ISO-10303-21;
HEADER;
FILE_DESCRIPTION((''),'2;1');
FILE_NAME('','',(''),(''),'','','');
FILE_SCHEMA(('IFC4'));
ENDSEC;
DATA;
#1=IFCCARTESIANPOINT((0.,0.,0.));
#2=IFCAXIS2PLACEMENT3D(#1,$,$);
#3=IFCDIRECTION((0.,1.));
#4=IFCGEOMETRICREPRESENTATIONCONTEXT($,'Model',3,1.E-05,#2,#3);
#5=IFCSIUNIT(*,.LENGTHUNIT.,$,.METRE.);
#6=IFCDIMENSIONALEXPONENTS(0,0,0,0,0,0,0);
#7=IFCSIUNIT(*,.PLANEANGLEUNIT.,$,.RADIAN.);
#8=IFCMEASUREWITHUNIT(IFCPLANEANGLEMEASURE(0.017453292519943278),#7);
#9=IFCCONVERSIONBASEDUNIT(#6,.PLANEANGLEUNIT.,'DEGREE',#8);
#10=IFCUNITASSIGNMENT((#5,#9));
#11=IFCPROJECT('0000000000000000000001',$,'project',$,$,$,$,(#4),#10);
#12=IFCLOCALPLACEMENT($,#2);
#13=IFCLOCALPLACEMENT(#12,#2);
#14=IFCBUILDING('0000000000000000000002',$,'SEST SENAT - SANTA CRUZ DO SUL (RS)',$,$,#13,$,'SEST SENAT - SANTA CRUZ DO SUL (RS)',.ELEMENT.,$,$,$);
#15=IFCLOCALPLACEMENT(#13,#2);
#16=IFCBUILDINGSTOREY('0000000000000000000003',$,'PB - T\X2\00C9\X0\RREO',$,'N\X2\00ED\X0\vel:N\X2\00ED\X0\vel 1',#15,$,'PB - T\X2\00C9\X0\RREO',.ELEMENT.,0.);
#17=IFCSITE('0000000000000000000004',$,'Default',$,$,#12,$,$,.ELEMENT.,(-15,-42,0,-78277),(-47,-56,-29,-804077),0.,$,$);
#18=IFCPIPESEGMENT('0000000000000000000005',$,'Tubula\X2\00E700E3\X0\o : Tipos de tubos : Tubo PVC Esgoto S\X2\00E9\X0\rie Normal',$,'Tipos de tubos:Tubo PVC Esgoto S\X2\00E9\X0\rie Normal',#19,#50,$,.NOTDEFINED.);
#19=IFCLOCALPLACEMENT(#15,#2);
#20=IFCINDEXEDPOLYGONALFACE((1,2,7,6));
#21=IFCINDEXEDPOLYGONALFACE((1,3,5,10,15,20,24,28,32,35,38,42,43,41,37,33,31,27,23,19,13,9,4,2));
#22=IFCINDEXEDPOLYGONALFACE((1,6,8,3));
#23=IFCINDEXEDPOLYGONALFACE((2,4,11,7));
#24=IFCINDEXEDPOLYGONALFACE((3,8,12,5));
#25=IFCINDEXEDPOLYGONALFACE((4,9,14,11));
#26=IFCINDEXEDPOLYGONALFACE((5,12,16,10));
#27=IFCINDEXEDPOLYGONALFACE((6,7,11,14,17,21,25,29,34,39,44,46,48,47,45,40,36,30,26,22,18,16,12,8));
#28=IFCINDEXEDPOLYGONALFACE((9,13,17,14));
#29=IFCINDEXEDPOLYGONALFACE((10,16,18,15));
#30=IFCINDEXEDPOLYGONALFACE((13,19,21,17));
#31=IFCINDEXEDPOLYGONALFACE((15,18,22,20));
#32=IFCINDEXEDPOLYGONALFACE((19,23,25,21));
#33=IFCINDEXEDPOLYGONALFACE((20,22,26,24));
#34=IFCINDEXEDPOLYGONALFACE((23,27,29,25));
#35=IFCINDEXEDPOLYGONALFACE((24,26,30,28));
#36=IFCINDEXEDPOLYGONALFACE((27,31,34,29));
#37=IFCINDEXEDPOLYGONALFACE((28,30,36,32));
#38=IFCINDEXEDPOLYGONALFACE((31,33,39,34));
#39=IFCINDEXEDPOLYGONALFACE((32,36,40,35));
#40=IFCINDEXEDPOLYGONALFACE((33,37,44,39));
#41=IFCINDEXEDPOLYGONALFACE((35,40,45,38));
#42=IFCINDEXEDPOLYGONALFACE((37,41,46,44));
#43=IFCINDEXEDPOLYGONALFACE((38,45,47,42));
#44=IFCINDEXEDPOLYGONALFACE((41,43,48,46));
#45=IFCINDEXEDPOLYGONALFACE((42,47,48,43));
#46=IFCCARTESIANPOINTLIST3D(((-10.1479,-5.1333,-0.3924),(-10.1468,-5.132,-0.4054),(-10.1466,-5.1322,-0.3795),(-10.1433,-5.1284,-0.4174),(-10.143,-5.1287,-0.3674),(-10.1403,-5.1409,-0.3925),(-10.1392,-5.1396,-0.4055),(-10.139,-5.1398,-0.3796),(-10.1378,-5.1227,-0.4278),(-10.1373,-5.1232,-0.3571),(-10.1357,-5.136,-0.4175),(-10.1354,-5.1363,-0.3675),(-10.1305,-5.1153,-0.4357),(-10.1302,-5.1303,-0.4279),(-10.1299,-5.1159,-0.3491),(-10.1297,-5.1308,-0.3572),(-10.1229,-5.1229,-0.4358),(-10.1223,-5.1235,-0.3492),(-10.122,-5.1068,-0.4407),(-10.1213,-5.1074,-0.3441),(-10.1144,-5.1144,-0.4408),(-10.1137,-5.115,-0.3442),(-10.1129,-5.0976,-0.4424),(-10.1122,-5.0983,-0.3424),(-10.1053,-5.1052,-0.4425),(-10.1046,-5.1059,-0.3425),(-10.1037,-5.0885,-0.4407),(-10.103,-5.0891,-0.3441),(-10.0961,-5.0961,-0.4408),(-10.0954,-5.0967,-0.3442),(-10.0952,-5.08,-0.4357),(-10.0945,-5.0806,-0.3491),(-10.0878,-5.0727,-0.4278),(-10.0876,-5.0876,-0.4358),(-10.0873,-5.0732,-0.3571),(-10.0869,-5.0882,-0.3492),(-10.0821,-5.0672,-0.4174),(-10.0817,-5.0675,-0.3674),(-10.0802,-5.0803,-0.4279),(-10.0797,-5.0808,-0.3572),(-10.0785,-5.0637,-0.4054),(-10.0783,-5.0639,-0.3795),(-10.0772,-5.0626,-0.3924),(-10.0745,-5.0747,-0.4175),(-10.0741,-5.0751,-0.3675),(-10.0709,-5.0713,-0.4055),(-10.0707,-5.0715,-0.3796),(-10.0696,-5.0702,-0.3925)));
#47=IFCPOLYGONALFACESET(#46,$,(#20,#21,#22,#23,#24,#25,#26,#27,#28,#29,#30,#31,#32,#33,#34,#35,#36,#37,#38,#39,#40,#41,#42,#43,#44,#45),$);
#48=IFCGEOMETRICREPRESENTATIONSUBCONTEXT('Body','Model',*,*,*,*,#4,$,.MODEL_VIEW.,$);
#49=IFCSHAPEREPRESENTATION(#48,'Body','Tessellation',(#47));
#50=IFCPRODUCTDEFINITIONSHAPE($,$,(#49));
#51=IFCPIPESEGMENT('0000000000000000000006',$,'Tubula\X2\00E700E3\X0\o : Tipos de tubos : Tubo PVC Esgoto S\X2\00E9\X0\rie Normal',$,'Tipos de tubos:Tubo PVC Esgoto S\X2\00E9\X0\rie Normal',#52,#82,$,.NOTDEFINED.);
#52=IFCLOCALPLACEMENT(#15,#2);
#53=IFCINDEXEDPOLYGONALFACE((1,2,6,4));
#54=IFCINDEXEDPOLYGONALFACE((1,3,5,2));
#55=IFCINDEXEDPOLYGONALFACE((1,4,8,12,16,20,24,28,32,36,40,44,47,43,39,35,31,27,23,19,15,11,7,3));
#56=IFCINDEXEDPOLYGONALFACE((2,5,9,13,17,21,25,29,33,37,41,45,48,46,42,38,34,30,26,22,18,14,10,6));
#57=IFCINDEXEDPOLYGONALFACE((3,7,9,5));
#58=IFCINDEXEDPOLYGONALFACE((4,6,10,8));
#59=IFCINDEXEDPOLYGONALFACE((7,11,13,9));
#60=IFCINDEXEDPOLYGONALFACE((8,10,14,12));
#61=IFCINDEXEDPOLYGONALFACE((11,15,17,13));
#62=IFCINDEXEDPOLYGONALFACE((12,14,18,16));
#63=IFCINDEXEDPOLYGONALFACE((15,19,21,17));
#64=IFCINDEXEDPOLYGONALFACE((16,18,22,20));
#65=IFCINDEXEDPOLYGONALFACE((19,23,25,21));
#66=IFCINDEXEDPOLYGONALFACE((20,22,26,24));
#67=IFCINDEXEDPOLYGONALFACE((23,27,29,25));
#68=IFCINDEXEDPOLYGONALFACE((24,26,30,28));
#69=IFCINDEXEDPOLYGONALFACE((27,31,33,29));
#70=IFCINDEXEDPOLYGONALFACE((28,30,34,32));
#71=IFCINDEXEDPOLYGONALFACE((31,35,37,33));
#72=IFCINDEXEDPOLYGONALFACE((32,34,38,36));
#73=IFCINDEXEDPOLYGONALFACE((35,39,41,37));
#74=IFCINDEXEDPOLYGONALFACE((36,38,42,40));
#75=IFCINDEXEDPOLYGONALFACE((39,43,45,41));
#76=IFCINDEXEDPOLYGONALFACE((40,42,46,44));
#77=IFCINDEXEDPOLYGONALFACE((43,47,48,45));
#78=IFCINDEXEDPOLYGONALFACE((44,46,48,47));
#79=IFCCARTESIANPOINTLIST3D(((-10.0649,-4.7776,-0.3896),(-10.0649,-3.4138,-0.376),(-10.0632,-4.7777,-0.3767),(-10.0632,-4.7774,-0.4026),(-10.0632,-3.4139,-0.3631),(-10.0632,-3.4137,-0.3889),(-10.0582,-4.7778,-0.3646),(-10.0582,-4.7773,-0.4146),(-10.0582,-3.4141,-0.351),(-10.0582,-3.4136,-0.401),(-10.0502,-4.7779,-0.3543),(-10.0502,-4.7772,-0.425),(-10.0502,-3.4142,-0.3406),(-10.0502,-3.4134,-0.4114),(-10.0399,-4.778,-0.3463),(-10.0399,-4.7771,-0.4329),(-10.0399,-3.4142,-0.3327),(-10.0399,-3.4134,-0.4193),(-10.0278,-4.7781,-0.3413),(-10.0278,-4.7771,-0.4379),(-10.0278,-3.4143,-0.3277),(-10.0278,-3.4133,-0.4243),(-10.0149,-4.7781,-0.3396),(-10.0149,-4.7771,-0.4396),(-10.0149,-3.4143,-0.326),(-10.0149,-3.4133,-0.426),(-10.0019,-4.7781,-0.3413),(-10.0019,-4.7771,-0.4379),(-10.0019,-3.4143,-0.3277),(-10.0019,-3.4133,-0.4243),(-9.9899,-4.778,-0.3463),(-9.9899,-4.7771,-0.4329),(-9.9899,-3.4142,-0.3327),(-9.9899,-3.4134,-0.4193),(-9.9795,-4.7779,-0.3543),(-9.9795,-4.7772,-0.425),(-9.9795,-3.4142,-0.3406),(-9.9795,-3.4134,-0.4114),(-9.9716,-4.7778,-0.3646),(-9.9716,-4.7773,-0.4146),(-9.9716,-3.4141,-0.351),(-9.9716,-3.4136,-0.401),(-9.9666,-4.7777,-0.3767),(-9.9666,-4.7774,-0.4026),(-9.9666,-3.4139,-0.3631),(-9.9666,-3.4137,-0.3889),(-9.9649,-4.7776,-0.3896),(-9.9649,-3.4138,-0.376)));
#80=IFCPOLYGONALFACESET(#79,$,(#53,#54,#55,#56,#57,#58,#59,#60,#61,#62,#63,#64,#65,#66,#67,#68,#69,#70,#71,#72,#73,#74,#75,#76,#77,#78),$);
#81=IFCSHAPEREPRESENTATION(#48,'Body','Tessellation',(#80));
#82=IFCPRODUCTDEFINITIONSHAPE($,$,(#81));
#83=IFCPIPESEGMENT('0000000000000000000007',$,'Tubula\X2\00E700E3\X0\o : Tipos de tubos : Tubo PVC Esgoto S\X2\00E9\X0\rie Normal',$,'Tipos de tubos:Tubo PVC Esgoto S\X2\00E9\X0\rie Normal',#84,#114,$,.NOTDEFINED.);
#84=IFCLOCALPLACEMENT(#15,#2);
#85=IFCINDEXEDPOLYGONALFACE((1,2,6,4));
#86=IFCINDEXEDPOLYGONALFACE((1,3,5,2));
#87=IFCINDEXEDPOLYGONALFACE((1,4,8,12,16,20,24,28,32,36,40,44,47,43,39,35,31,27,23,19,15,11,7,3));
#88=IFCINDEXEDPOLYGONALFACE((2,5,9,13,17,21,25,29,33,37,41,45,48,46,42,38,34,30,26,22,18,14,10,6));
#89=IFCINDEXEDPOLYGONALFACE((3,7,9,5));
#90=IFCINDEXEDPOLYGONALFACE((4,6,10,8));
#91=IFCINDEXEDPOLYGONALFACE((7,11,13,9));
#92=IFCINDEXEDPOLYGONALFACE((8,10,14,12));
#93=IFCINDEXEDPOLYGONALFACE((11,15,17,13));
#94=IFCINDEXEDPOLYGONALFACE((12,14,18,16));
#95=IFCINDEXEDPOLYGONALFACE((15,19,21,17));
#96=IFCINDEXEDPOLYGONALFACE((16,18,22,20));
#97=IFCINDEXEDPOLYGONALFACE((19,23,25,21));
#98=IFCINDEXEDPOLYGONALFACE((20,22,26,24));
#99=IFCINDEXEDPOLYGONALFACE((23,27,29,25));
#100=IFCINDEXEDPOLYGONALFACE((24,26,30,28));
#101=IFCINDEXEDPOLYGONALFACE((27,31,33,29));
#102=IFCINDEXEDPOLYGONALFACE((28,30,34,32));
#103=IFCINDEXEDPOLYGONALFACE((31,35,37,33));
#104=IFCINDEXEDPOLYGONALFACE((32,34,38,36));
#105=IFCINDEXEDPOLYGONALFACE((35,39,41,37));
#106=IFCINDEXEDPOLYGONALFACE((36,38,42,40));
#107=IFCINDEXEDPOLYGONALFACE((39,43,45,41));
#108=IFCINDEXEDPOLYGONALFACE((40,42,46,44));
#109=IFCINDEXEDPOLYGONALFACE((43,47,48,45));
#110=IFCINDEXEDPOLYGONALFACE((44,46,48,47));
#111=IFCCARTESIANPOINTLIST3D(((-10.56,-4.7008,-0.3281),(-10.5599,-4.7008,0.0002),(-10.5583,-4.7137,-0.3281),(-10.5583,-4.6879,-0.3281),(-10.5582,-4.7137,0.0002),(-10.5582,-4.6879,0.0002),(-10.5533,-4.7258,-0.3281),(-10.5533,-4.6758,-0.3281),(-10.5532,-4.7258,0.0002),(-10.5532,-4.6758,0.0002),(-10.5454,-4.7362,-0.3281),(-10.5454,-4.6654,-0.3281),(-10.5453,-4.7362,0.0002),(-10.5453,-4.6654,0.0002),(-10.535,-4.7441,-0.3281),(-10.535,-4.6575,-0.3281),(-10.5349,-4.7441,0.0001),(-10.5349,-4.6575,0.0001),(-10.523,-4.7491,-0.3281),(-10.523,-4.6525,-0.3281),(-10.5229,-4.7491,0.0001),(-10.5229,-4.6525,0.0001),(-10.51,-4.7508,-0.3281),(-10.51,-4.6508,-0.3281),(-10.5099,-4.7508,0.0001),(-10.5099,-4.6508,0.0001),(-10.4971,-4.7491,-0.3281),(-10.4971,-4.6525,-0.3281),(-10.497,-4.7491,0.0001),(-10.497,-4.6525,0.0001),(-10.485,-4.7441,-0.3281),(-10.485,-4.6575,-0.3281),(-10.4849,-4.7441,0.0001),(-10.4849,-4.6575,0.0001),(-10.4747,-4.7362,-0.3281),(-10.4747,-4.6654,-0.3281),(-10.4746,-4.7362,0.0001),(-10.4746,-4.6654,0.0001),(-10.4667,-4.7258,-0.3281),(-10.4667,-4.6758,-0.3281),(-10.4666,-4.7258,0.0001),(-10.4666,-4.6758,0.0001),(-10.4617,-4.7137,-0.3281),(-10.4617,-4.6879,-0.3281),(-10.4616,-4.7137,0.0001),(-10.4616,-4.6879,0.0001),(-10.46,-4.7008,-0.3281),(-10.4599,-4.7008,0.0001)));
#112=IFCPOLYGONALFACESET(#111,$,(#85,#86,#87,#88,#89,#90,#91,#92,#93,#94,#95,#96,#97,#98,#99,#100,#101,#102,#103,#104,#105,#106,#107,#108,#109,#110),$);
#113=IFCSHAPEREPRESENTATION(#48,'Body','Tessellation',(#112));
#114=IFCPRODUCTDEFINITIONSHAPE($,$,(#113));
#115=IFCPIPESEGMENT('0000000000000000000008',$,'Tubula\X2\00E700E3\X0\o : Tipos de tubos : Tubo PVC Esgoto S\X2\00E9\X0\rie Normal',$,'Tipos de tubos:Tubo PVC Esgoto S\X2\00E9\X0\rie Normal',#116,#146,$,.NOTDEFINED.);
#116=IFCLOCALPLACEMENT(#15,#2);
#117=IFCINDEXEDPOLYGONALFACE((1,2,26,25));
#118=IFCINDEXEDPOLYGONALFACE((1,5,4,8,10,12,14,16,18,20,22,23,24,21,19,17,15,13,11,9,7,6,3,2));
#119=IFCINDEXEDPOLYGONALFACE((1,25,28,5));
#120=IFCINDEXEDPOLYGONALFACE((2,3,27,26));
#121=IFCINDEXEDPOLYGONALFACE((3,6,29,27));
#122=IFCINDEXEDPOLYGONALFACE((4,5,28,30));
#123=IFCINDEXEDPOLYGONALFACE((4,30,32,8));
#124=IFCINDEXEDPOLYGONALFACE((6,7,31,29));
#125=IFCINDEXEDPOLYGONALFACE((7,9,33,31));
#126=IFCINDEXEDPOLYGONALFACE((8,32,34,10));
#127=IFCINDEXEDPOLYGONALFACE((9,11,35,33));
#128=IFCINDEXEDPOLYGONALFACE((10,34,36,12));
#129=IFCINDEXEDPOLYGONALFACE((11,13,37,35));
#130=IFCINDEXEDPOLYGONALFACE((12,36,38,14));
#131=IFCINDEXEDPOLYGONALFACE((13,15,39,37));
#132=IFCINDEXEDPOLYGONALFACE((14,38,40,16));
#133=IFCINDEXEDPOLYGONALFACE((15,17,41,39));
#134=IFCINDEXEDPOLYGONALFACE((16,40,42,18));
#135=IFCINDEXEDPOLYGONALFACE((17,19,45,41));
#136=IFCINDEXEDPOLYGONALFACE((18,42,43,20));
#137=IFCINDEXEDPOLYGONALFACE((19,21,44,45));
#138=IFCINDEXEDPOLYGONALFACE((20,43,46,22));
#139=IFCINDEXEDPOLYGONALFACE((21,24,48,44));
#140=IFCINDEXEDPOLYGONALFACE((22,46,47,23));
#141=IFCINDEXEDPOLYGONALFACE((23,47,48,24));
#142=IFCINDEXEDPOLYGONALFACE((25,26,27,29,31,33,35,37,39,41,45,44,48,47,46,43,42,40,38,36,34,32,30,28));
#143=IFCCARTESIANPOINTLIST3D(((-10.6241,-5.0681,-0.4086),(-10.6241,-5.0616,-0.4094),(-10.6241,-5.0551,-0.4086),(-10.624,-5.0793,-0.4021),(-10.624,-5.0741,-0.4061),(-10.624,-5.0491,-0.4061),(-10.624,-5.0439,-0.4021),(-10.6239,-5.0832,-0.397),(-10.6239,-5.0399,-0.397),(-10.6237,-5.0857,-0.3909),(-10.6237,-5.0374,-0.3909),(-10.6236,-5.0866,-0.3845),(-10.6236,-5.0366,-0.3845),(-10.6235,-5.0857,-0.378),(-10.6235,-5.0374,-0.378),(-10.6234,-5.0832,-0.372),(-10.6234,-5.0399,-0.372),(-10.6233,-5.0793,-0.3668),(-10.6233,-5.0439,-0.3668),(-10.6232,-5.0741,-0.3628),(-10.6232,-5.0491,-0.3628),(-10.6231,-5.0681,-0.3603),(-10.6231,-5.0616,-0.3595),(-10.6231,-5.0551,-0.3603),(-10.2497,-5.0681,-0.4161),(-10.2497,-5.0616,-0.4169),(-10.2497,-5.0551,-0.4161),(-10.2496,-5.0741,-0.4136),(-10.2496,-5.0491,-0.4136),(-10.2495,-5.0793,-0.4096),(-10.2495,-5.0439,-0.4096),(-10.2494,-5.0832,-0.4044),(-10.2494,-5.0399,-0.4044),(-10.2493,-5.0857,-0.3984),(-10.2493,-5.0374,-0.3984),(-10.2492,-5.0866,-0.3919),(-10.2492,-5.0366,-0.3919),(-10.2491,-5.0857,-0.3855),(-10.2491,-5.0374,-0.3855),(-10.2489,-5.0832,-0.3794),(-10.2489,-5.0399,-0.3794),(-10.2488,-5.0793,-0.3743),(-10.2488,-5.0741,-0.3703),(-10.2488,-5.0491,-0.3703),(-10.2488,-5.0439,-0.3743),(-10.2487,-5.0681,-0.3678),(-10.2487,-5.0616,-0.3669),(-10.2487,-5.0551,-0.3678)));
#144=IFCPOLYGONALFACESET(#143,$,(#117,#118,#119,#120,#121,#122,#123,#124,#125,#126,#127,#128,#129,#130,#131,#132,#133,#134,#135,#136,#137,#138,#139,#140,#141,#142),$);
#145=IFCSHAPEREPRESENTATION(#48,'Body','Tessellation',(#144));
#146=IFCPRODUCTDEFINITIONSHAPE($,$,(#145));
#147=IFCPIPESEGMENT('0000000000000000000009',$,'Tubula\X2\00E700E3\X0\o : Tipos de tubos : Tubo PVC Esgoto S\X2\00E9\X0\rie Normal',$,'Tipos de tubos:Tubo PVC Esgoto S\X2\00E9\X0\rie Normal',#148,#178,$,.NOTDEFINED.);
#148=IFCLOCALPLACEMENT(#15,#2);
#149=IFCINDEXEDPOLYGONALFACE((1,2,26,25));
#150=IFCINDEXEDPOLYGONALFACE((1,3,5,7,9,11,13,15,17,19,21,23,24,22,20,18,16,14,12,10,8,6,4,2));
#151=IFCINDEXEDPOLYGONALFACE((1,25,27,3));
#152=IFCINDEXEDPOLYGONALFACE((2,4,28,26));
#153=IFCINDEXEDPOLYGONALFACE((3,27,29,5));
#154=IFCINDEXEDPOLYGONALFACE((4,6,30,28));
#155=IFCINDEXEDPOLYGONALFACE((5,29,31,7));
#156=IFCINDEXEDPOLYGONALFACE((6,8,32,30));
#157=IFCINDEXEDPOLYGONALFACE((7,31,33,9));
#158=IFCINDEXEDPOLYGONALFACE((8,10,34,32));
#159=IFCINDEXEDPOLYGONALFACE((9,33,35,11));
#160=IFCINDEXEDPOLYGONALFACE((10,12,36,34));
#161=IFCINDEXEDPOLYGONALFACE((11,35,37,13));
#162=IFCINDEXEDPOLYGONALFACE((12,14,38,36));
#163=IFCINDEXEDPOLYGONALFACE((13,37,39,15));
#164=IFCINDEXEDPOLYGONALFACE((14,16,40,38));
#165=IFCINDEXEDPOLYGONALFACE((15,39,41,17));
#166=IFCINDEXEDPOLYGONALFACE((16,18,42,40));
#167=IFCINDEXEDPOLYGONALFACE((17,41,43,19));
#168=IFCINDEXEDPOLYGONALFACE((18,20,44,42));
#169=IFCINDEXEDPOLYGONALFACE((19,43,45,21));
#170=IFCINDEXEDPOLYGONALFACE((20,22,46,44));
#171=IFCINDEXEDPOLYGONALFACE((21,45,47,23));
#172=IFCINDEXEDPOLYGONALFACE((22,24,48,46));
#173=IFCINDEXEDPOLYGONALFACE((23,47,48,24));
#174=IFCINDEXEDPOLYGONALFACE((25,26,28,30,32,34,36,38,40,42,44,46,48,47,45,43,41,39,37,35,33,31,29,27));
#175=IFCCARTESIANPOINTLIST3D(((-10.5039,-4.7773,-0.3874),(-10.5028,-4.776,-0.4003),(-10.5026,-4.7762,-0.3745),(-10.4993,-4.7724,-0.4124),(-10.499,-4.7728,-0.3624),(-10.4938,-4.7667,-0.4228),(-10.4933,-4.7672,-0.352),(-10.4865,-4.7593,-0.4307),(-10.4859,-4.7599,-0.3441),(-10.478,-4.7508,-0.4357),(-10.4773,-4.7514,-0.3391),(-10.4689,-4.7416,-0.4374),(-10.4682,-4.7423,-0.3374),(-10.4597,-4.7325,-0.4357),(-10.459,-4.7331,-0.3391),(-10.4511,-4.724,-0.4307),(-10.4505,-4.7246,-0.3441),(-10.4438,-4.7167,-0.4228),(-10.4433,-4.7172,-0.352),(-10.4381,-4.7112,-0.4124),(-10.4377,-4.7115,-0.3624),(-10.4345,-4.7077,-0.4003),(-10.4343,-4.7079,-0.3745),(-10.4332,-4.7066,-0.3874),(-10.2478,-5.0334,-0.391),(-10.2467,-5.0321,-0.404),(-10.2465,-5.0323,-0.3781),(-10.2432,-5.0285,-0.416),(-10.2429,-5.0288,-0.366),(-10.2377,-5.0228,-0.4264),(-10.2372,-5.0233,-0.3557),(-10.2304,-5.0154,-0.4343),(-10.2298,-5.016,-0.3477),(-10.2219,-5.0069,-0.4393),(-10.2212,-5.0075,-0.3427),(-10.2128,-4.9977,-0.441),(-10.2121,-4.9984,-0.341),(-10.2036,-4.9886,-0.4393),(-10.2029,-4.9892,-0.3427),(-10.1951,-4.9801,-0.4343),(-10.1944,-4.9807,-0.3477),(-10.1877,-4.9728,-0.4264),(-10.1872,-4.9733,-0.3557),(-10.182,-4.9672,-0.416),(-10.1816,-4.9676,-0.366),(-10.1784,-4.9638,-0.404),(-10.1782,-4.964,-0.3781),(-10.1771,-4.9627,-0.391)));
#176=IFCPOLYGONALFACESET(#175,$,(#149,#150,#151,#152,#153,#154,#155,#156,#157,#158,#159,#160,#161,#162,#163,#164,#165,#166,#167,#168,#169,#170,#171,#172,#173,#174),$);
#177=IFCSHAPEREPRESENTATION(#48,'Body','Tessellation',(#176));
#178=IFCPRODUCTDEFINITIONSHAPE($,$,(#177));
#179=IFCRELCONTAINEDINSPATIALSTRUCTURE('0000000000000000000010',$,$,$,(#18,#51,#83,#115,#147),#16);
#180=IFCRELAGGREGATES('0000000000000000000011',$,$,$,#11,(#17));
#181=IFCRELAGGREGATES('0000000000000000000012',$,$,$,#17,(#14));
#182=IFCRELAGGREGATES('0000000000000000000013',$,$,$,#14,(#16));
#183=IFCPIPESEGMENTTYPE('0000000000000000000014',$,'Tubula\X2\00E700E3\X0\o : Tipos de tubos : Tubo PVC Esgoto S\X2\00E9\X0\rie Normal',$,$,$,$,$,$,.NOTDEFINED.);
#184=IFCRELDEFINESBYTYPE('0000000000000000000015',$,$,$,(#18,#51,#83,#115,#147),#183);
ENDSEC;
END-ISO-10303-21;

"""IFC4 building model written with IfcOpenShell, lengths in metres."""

from ifc_helpers import new_model, entity, si_unit, converted_unit, direction, frame, origin, place, context, subcontext, project, spatial, arc, indexed_curve, outline, extrude, type_object, element, save


model = new_model("IFC4")

# Units and contexts
model_context = context("Model", 3, precision=1e-05, world=origin(), true_north=direction((0.0, 1.0)))
body_context = subcontext(model_context, "Body", "Model", "MODEL_VIEW")
ifc_project = project(units=[si_unit("LENGTHUNIT", "METRE"), converted_unit("PLANEANGLEUNIT", "DEGREE", entity("IfcPlaneAngleMeasure", 0.017453292519943278), si_unit("PLANEANGLEUNIT", "RADIAN"), dimensions=[0, 0, 0, 0, 0, 0, 0])], contexts=[model_context])

# Site, building, storey
site_placement = place(None, origin())
site = spatial("IfcSite", under=ifc_project, at=site_placement, Name="Default", CompositionType="ELEMENT", RefLatitude=(-15, -42, 0, -78277), RefLongitude=(-47, -56, -29, -804077), RefElevation=0.0)
building_placement = place(site_placement, origin())
building = spatial("IfcBuilding", under=site, at=building_placement, Name="SEST SENAT - SANTA CRUZ DO SUL (RS)", LongName="SEST SENAT - SANTA CRUZ DO SUL (RS)", CompositionType="ELEMENT")
storey_placement = place(building_placement, origin())
storey = spatial("IfcBuildingStorey", under=building, at=storey_placement, Name="PB - TÉRREO", ObjectType="Nível:Nível 1", LongName="PB - TÉRREO", CompositionType="ELEMENT", Elevation=0.0)

# Pipe segments
pipe_segment_type = type_object("IfcPipeSegmentType", Name="Tubulação : Tipos de tubos : Tubo PVC Esgoto Série Normal", PredefinedType="NOTDEFINED")
pipe_segment_1_placement = place(storey_placement, frame((-10.1495, -5.1425, -0.3408)))
element("IfcPipeSegment", 1, at=pipe_segment_1_placement, inside=storey, type_object=pipe_segment_type, Name="Tubulação : Tipos de tubos : Tubo PVC Esgoto Série Normal", ObjectType="Tipos de tubos:Tubo PVC Esgoto Série Normal", PredefinedType="NOTDEFINED", context=body_context, shape_type="SweptSolid", body=[
    extrude(outline(indexed_curve([(0.05, 0.0), (0.0354, 0.0354), (0.0, 0.05), (-0.0354, 0.0354), (-0.05, 0.0), (-0.0354, -0.0354), (0.0, -0.05), (0.0354, -0.0354)], segments=[arc(1, 2, 3), arc(3, 4, 5), arc(5, 6, 7), arc(7, 8, 1)], self_intersect=False)), frame((0.0445, 0.037, -0.0517), z_axis=(-0.707071, 0.707071, 0.01), x_axis=(-0.707107, -0.707107, 0.0)), (0.0, 0.0, 1.0), 0.0107),
])
pipe_segment_2_placement = place(storey_placement, frame((-10.0665, -4.7797, -0.4412)))
element("IfcPipeSegment", 2, at=pipe_segment_2_placement, inside=storey, type_object=pipe_segment_type, Name="Tubulação : Tipos de tubos : Tubo PVC Esgoto Série Normal", ObjectType="Tipos de tubos:Tubo PVC Esgoto Série Normal", PredefinedType="NOTDEFINED", context=body_context, shape_type="SweptSolid", body=[
    extrude(outline(indexed_curve([(0.05, 0.0), (0.0354, 0.0354), (0.0, 0.05), (-0.0354, 0.0354), (-0.05, 0.0), (-0.0354, -0.0354), (0.0, -0.05), (0.0354, -0.0354)], segments=[arc(1, 2, 3), arc(3, 4, 5), arc(5, 6, 7), arc(7, 8, 1)], self_intersect=False)), frame((0.0516, 0.0021, 0.0516), z_axis=(0.0, 0.99995, 0.01), x_axis=(-1.0, 0.0, 0.0)), (0.0, 0.0, 1.0), 1.3638),
])
pipe_segment_3_placement = place(storey_placement, frame((-10.5616, -4.7524, -0.3281)))
element("IfcPipeSegment", 3, at=pipe_segment_3_placement, inside=storey, type_object=pipe_segment_type, Name="Tubulação : Tipos de tubos : Tubo PVC Esgoto Série Normal", ObjectType="Tipos de tubos:Tubo PVC Esgoto Série Normal", PredefinedType="NOTDEFINED", context=body_context, shape_type="SweptSolid", body=[
    extrude(outline(indexed_curve([(0.05, 0.0), (0.0354, 0.0354), (0.0, 0.05), (-0.0354, 0.0354), (-0.05, 0.0), (-0.0354, -0.0354), (0.0, -0.05), (0.0354, -0.0354)], segments=[arc(1, 2, 3), arc(3, 4, 5), arc(5, 6, 7), arc(7, 8, 1)], self_intersect=False)), frame((0.0516, 0.0516, 0.0), z_axis=(0.000292, 0.0, 1.0), x_axis=(-1.0, 0.0, 0.000292)), (0.0, 0.0, 1.0), 0.3283),
])
pipe_segment_4_placement = place(storey_placement, frame((-10.6257, -5.0882, -0.3579)))
element("IfcPipeSegment", 4, at=pipe_segment_4_placement, inside=storey, type_object=pipe_segment_type, Name="Tubulação : Tipos de tubos : Tubo PVC Esgoto Série Normal", ObjectType="Tipos de tubos:Tubo PVC Esgoto Série Normal", PredefinedType="NOTDEFINED", context=body_context, shape_type="SweptSolid", body=[
    extrude(outline(indexed_curve([(0.025, 0.0), (0.0177, 0.0177), (0.0, 0.025), (-0.0177, 0.0177), (-0.025, 0.0), (-0.0177, -0.0177), (0.0, -0.025), (0.0177, -0.0177)], segments=[arc(1, 2, 3), arc(3, 4, 5), arc(5, 6, 7), arc(7, 8, 1)], self_intersect=False)), frame((0.0021, 0.0266, -0.0266), z_axis=(0.9998, 0.0, -0.019997), x_axis=(0.0, 1.0, 0.0)), (0.0, 0.0, 1.0), 0.3745),
])
pipe_segment_5_placement = place(storey_placement, frame((-10.5055, -5.035, -0.3358)))
element("IfcPipeSegment", 5, at=pipe_segment_5_placement, inside=storey, type_object=pipe_segment_type, Name="Tubulação : Tipos de tubos : Tubo PVC Esgoto Série Normal", ObjectType="Tipos de tubos:Tubo PVC Esgoto Série Normal", PredefinedType="NOTDEFINED", context=body_context, shape_type="SweptSolid", body=[
    extrude(outline(indexed_curve([(0.05, 0.0), (0.0354, 0.0354), (0.0, 0.05), (-0.0354, 0.0354), (-0.05, 0.0), (-0.0354, -0.0354), (0.0, -0.05), (0.0354, -0.0354)], segments=[arc(1, 2, 3), arc(3, 4, 5), arc(5, 6, 7), arc(7, 8, 1)], self_intersect=False)), frame((0.293, 0.037, -0.0552), z_axis=(-0.707071, 0.707071, 0.01), x_axis=(-0.707107, -0.707107, 0.0)), (0.0, 0.0, 1.0), 0.3622),
])

save(model, "model.ifc")
